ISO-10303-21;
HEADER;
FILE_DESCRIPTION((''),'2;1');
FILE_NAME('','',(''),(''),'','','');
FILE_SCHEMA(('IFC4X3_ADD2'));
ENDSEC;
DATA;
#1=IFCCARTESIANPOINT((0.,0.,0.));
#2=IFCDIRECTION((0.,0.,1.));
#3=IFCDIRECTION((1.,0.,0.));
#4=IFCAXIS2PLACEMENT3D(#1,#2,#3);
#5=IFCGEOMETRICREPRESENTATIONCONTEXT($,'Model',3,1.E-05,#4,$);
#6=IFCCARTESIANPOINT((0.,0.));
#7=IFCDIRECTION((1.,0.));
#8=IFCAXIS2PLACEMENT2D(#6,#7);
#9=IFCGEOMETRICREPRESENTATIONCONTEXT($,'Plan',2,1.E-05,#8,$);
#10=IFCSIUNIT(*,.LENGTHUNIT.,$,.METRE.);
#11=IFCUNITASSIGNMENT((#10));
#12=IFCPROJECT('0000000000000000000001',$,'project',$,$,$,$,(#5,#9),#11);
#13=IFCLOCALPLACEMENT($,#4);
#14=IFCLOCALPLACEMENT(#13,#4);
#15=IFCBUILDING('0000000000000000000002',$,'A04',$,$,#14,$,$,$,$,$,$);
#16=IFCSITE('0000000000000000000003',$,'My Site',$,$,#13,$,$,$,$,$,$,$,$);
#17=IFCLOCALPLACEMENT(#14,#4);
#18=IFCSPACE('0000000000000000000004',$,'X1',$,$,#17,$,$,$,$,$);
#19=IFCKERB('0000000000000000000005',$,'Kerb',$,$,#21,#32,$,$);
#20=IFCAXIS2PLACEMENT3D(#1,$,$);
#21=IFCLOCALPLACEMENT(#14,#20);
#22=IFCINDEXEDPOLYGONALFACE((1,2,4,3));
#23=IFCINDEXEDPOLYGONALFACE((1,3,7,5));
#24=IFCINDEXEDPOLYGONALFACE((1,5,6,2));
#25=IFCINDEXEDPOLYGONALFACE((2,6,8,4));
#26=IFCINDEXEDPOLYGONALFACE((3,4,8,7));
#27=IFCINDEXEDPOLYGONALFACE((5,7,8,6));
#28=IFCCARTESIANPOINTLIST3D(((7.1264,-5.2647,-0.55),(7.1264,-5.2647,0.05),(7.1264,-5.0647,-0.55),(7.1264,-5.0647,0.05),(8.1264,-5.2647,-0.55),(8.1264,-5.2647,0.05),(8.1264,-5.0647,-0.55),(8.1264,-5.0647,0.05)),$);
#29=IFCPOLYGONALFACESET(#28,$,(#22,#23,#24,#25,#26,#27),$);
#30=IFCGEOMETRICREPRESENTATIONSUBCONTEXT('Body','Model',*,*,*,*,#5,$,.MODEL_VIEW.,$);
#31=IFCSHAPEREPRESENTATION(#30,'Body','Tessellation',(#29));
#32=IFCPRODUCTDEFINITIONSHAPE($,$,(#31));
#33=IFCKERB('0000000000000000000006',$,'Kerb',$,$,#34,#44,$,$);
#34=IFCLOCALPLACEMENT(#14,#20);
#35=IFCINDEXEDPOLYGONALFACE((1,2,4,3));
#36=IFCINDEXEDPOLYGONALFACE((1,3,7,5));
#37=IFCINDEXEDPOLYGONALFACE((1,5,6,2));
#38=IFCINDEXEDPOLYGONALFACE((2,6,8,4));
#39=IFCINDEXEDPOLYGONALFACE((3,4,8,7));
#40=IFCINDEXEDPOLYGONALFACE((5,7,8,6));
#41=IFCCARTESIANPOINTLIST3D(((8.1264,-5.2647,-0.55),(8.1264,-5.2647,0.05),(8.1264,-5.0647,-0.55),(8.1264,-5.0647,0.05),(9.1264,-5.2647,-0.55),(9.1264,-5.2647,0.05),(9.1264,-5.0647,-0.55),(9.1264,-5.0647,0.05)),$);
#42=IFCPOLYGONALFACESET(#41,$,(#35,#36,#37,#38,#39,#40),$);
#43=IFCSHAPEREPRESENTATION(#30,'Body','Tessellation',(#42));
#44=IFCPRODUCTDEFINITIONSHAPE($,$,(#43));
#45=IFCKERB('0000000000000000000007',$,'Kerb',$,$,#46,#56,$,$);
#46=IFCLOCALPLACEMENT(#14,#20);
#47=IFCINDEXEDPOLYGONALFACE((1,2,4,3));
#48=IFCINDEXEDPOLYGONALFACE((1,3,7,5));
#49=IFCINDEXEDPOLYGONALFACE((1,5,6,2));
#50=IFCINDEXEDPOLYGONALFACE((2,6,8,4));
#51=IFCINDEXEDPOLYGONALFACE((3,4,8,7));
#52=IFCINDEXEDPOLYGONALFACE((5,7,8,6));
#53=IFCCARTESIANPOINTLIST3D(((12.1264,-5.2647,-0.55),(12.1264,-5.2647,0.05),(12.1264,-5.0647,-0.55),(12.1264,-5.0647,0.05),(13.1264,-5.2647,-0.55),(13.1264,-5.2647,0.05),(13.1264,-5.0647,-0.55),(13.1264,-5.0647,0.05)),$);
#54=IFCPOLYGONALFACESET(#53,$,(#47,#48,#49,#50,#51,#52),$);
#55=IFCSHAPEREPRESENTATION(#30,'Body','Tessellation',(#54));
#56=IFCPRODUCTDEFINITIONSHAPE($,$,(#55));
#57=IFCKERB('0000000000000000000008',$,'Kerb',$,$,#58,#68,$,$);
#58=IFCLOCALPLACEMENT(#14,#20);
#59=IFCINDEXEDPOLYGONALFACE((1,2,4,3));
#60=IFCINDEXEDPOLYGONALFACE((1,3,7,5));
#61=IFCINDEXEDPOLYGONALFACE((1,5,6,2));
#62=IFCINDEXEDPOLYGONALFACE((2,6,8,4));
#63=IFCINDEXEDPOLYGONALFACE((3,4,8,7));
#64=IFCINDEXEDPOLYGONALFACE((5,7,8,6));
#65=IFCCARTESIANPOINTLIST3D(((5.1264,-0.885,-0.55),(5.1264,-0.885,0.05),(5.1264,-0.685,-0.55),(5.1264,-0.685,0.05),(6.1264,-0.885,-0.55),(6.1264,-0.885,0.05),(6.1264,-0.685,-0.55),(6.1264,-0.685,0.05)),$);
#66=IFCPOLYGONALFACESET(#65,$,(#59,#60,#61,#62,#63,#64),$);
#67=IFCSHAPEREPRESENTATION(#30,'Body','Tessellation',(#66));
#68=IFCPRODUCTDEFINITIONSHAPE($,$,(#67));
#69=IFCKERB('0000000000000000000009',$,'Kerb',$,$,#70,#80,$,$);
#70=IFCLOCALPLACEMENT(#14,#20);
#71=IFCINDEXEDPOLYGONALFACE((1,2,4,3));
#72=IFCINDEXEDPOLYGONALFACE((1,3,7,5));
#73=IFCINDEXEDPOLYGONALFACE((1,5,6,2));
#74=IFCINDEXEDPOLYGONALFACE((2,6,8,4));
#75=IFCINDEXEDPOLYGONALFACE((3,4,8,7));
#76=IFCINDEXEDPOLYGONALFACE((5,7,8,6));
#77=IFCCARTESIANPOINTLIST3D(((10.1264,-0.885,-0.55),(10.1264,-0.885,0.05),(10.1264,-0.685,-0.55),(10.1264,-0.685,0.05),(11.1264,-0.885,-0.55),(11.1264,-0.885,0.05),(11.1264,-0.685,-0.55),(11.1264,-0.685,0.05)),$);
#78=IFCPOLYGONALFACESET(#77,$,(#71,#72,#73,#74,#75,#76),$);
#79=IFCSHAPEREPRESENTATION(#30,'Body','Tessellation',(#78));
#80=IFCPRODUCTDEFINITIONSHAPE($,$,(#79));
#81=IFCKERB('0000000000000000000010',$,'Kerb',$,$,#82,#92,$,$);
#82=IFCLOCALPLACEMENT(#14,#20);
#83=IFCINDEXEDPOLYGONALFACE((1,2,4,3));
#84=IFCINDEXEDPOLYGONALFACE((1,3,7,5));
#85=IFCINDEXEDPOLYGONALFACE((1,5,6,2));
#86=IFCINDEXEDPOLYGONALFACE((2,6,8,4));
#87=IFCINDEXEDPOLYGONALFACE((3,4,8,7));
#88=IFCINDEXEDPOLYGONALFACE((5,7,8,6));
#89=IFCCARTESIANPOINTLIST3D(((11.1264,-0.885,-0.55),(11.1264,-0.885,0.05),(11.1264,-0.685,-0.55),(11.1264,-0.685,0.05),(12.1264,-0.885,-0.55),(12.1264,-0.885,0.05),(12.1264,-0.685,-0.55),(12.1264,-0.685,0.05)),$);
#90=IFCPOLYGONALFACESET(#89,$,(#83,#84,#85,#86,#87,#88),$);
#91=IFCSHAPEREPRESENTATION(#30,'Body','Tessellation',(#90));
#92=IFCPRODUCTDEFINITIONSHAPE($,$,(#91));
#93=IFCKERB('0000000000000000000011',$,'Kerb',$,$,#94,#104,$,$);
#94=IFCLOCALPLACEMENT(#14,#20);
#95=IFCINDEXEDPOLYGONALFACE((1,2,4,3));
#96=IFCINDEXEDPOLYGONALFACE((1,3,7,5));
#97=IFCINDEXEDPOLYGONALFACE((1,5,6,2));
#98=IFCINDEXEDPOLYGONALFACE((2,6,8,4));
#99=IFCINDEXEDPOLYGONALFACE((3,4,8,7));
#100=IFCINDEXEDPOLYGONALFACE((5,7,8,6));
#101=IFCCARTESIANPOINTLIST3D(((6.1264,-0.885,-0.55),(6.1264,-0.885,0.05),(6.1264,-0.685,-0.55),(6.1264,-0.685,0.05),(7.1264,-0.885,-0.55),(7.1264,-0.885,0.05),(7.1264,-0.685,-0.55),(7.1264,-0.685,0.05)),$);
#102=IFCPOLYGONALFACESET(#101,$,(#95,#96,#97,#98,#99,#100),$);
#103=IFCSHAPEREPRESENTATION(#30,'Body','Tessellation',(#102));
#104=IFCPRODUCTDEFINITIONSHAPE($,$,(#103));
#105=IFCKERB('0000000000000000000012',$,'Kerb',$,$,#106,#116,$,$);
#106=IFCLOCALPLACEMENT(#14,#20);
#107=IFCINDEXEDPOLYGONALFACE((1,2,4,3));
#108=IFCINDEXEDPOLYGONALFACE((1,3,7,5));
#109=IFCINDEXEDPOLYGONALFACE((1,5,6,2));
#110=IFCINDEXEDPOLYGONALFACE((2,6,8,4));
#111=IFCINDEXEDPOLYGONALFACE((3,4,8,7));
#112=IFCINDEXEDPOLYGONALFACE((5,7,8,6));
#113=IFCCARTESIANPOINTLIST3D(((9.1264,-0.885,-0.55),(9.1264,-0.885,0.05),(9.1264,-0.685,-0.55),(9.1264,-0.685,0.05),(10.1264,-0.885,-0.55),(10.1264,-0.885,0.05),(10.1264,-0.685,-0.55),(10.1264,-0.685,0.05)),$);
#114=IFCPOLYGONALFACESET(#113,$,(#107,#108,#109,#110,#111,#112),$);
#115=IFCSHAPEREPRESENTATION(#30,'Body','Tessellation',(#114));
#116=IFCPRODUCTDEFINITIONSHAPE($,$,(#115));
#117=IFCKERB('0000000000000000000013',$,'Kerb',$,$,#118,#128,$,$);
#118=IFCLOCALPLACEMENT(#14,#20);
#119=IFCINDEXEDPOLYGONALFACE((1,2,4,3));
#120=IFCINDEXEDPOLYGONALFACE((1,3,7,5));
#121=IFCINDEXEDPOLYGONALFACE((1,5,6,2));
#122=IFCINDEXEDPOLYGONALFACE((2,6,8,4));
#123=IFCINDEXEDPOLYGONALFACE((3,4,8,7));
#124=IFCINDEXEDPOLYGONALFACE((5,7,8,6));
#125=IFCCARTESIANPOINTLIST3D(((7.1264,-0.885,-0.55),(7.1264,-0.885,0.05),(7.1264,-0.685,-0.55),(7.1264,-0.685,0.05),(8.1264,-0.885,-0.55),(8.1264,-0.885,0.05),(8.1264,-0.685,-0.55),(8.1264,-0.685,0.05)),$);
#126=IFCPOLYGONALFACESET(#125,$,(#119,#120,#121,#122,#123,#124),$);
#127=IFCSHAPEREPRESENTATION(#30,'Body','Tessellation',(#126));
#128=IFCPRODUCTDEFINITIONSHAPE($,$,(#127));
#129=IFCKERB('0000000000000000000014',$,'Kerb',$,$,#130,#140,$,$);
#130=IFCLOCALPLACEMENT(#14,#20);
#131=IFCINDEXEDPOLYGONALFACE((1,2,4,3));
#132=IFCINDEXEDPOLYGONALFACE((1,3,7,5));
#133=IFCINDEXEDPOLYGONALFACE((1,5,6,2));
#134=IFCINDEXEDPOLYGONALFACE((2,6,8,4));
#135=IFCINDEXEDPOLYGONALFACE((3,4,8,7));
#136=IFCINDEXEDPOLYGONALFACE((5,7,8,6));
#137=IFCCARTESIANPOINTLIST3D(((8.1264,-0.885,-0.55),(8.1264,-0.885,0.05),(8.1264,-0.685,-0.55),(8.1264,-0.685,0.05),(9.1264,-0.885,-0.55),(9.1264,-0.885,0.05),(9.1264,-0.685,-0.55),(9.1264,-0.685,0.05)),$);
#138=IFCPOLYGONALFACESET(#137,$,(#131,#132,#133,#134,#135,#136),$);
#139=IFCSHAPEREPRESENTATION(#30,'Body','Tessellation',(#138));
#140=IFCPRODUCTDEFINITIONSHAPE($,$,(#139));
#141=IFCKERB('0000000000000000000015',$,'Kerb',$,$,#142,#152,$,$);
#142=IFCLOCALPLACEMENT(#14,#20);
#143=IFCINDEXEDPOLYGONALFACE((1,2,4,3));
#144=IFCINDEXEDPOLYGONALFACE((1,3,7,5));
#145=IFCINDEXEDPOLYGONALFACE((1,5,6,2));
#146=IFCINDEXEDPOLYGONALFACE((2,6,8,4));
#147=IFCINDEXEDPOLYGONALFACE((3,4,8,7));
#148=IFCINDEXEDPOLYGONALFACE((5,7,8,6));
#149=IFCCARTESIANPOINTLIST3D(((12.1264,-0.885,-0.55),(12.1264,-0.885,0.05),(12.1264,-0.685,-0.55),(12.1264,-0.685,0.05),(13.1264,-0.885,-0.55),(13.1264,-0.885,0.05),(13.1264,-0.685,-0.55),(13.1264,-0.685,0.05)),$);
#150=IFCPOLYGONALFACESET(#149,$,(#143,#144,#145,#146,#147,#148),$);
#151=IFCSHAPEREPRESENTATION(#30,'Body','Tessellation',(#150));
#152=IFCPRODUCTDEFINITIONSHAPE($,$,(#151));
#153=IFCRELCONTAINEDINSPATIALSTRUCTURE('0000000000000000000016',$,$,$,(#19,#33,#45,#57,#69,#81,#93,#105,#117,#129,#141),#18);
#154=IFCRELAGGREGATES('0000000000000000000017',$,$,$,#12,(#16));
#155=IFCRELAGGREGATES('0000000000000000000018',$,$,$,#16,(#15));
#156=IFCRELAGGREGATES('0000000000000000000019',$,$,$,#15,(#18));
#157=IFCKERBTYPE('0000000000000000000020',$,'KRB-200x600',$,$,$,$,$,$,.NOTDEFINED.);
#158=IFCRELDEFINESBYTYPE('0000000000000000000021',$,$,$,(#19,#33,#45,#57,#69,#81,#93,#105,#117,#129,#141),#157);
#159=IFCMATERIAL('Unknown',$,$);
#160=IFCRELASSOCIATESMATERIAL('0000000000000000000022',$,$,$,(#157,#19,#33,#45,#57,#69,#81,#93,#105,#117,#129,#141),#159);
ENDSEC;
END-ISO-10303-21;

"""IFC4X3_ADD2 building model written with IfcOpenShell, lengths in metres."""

from ifc_helpers import new_model, si_unit, frame, origin_with_axes, origin_2d_with_axis, place, context, subcontext, project, spatial, rectangle, extrude, material, material_profile, profile_set, profile_usage, type_object, element, save


model = new_model("IFC4X3_ADD2")

# Units and contexts
model_context = context("Model", 3, precision=1e-05, world=origin_with_axes())
plan_context = context("Plan", 2, precision=1e-05, world=origin_2d_with_axis())
body_context = subcontext(model_context, "Body", "Model", "MODEL_VIEW")
ifc_project = project(units=[si_unit("LENGTHUNIT", "METRE")], contexts=[model_context, plan_context])

# Site, building, space
site_placement = place(None, origin_with_axes())
site = spatial("IfcSite", under=ifc_project, at=site_placement, Name="My Site")
building_placement = place(site_placement, origin_with_axes())
building = spatial("IfcBuilding", under=site, at=building_placement, Name="A04")
space_placement = place(building_placement, origin_with_axes())
space = spatial("IfcSpace", under=building, at=space_placement, Name="X1")

# Shared definitions
ifc_material = material(Name="Unknown")

# Kerbs
ifc_material_profile_1 = material_profile(ifc_material, rectangle(XDim=0.2, YDim=0.6))
ifc_profile_set_1 = profile_set([ifc_material_profile_1])
kerb_type = type_object("IfcKerbType", Name="KRB-200x600", PredefinedType="NOTDEFINED", material=ifc_profile_set_1)
ifc_profile_usage_1 = profile_usage(ifc_profile_set_1, cardinal=2)
kerb_1_placement = place(space_placement, frame((7.1264, -5.1647, -0.55), z_axis=(1.0, 0.0, 0.0), x_axis=(0.0, 1.0, 0.0)))
element("IfcKerb", 1, at=kerb_1_placement, inside=space, type_object=kerb_type, material=ifc_profile_usage_1, Name="Kerb", context=body_context, shape_type="SweptSolid", body=[
    extrude(rectangle(XDim=0.2, YDim=0.6), frame((0.0, 0.3, 0.0), z_axis=(0.0, 0.0, 1.0), x_axis=(1.0, 0.0, 0.0)), (0.0, 0.0, 1.0), 1.0),
])
ifc_profile_usage_2 = profile_usage(ifc_profile_set_1, cardinal=2)
kerb_2_placement = place(space_placement, frame((8.1264, -5.1647, -0.55), z_axis=(1.0, 0.0, 0.0), x_axis=(0.0, 1.0, 0.0)))
element("IfcKerb", 2, at=kerb_2_placement, inside=space, type_object=kerb_type, material=ifc_profile_usage_2, Name="Kerb", context=body_context, shape_type="SweptSolid", body=[
    extrude(rectangle(XDim=0.2, YDim=0.6), frame((0.0, 0.3, 0.0), z_axis=(0.0, 0.0, 1.0), x_axis=(1.0, 0.0, 0.0)), (0.0, 0.0, 1.0), 1.0),
])
ifc_profile_usage_3 = profile_usage(ifc_profile_set_1, cardinal=2)
kerb_3_placement = place(space_placement, frame((12.1264, -5.1647, -0.55), z_axis=(1.0, 0.0, 0.0), x_axis=(0.0, 1.0, 0.0)))
element("IfcKerb", 3, at=kerb_3_placement, inside=space, type_object=kerb_type, material=ifc_profile_usage_3, Name="Kerb", context=body_context, shape_type="SweptSolid", body=[
    extrude(rectangle(XDim=0.2, YDim=0.6), frame((0.0, 0.3, 0.0), z_axis=(0.0, 0.0, 1.0), x_axis=(1.0, 0.0, 0.0)), (0.0, 0.0, 1.0), 1.0),
])
ifc_profile_usage_4 = profile_usage(ifc_profile_set_1, cardinal=2)
kerb_4_placement = place(space_placement, frame((5.1264, -0.785, -0.55), z_axis=(1.0, 0.0, 0.0), x_axis=(0.0, 1.0, 0.0)))
element("IfcKerb", 4, at=kerb_4_placement, inside=space, type_object=kerb_type, material=ifc_profile_usage_4, Name="Kerb", context=body_context, shape_type="SweptSolid", body=[
    extrude(rectangle(XDim=0.2, YDim=0.6), frame((0.0, 0.3, 0.0), z_axis=(0.0, 0.0, 1.0), x_axis=(1.0, 0.0, 0.0)), (0.0, 0.0, 1.0), 1.0),
])
ifc_profile_usage_5 = profile_usage(ifc_profile_set_1, cardinal=2)
kerb_5_placement = place(space_placement, frame((10.1264, -0.785, -0.55), z_axis=(1.0, 0.0, 0.0), x_axis=(0.0, 1.0, 0.0)))
element("IfcKerb", 5, at=kerb_5_placement, inside=space, type_object=kerb_type, material=ifc_profile_usage_5, Name="Kerb", context=body_context, shape_type="SweptSolid", body=[
    extrude(rectangle(XDim=0.2, YDim=0.6), frame((0.0, 0.3, 0.0), z_axis=(0.0, 0.0, 1.0), x_axis=(1.0, 0.0, 0.0)), (0.0, 0.0, 1.0), 1.0),
])
ifc_profile_usage_6 = profile_usage(ifc_profile_set_1, cardinal=2)
kerb_6_placement = place(space_placement, frame((11.1264, -0.785, -0.55), z_axis=(1.0, 0.0, 0.0), x_axis=(0.0, 1.0, 0.0)))
element("IfcKerb", 6, at=kerb_6_placement, inside=space, type_object=kerb_type, material=ifc_profile_usage_6, Name="Kerb", context=body_context, shape_type="SweptSolid", body=[
    extrude(rectangle(XDim=0.2, YDim=0.6), frame((0.0, 0.3, 0.0), z_axis=(0.0, 0.0, 1.0), x_axis=(1.0, 0.0, 0.0)), (0.0, 0.0, 1.0), 1.0),
])
ifc_profile_usage_7 = profile_usage(ifc_profile_set_1, cardinal=2)
kerb_7_placement = place(space_placement, frame((6.1264, -0.785, -0.55), z_axis=(1.0, 0.0, 0.0), x_axis=(0.0, 1.0, 0.0)))
element("IfcKerb", 7, at=kerb_7_placement, inside=space, type_object=kerb_type, material=ifc_profile_usage_7, Name="Kerb", context=body_context, shape_type="SweptSolid", body=[
    extrude(rectangle(XDim=0.2, YDim=0.6), frame((0.0, 0.3, 0.0), z_axis=(0.0, 0.0, 1.0), x_axis=(1.0, 0.0, 0.0)), (0.0, 0.0, 1.0), 1.0),
])
ifc_profile_usage_8 = profile_usage(ifc_profile_set_1, cardinal=2)
kerb_8_placement = place(space_placement, frame((9.1264, -0.785, -0.55), z_axis=(1.0, 0.0, 0.0), x_axis=(0.0, 1.0, 0.0)))
element("IfcKerb", 8, at=kerb_8_placement, inside=space, type_object=kerb_type, material=ifc_profile_usage_8, Name="Kerb", context=body_context, shape_type="SweptSolid", body=[
    extrude(rectangle(XDim=0.2, YDim=0.6), frame((0.0, 0.3, 0.0), z_axis=(0.0, 0.0, 1.0), x_axis=(1.0, 0.0, 0.0)), (0.0, 0.0, 1.0), 1.0),
])
ifc_profile_usage_9 = profile_usage(ifc_profile_set_1, cardinal=2)
kerb_9_placement = place(space_placement, frame((7.1264, -0.785, -0.55), z_axis=(1.0, 0.0, 0.0), x_axis=(0.0, 1.0, 0.0)))
element("IfcKerb", 9, at=kerb_9_placement, inside=space, type_object=kerb_type, material=ifc_profile_usage_9, Name="Kerb", context=body_context, shape_type="SweptSolid", body=[
    extrude(rectangle(XDim=0.2, YDim=0.6), frame((0.0, 0.3, 0.0), z_axis=(0.0, 0.0, 1.0), x_axis=(1.0, 0.0, 0.0)), (0.0, 0.0, 1.0), 1.0),
])
ifc_profile_usage_10 = profile_usage(ifc_profile_set_1, cardinal=2)
kerb_10_placement = place(space_placement, frame((8.1264, -0.785, -0.55), z_axis=(1.0, 0.0, 0.0), x_axis=(0.0, 1.0, 0.0)))
element("IfcKerb", 10, at=kerb_10_placement, inside=space, type_object=kerb_type, material=ifc_profile_usage_10, Name="Kerb", context=body_context, shape_type="SweptSolid", body=[
    extrude(rectangle(XDim=0.2, YDim=0.6), frame((0.0, 0.3, 0.0), z_axis=(0.0, 0.0, 1.0), x_axis=(1.0, 0.0, 0.0)), (0.0, 0.0, 1.0), 1.0),
])
ifc_profile_usage_11 = profile_usage(ifc_profile_set_1, cardinal=2)
kerb_11_placement = place(space_placement, frame((12.1264, -0.785, -0.55), z_axis=(1.0, 0.0, 0.0), x_axis=(0.0, 1.0, 0.0)))
element("IfcKerb", 11, at=kerb_11_placement, inside=space, type_object=kerb_type, material=ifc_profile_usage_11, Name="Kerb", context=body_context, shape_type="SweptSolid", body=[
    extrude(rectangle(XDim=0.2, YDim=0.6), frame((0.0, 0.3, 0.0), z_axis=(0.0, 0.0, 1.0), x_axis=(1.0, 0.0, 0.0)), (0.0, 0.0, 1.0), 1.0),
])

save(model, "model.ifc")
